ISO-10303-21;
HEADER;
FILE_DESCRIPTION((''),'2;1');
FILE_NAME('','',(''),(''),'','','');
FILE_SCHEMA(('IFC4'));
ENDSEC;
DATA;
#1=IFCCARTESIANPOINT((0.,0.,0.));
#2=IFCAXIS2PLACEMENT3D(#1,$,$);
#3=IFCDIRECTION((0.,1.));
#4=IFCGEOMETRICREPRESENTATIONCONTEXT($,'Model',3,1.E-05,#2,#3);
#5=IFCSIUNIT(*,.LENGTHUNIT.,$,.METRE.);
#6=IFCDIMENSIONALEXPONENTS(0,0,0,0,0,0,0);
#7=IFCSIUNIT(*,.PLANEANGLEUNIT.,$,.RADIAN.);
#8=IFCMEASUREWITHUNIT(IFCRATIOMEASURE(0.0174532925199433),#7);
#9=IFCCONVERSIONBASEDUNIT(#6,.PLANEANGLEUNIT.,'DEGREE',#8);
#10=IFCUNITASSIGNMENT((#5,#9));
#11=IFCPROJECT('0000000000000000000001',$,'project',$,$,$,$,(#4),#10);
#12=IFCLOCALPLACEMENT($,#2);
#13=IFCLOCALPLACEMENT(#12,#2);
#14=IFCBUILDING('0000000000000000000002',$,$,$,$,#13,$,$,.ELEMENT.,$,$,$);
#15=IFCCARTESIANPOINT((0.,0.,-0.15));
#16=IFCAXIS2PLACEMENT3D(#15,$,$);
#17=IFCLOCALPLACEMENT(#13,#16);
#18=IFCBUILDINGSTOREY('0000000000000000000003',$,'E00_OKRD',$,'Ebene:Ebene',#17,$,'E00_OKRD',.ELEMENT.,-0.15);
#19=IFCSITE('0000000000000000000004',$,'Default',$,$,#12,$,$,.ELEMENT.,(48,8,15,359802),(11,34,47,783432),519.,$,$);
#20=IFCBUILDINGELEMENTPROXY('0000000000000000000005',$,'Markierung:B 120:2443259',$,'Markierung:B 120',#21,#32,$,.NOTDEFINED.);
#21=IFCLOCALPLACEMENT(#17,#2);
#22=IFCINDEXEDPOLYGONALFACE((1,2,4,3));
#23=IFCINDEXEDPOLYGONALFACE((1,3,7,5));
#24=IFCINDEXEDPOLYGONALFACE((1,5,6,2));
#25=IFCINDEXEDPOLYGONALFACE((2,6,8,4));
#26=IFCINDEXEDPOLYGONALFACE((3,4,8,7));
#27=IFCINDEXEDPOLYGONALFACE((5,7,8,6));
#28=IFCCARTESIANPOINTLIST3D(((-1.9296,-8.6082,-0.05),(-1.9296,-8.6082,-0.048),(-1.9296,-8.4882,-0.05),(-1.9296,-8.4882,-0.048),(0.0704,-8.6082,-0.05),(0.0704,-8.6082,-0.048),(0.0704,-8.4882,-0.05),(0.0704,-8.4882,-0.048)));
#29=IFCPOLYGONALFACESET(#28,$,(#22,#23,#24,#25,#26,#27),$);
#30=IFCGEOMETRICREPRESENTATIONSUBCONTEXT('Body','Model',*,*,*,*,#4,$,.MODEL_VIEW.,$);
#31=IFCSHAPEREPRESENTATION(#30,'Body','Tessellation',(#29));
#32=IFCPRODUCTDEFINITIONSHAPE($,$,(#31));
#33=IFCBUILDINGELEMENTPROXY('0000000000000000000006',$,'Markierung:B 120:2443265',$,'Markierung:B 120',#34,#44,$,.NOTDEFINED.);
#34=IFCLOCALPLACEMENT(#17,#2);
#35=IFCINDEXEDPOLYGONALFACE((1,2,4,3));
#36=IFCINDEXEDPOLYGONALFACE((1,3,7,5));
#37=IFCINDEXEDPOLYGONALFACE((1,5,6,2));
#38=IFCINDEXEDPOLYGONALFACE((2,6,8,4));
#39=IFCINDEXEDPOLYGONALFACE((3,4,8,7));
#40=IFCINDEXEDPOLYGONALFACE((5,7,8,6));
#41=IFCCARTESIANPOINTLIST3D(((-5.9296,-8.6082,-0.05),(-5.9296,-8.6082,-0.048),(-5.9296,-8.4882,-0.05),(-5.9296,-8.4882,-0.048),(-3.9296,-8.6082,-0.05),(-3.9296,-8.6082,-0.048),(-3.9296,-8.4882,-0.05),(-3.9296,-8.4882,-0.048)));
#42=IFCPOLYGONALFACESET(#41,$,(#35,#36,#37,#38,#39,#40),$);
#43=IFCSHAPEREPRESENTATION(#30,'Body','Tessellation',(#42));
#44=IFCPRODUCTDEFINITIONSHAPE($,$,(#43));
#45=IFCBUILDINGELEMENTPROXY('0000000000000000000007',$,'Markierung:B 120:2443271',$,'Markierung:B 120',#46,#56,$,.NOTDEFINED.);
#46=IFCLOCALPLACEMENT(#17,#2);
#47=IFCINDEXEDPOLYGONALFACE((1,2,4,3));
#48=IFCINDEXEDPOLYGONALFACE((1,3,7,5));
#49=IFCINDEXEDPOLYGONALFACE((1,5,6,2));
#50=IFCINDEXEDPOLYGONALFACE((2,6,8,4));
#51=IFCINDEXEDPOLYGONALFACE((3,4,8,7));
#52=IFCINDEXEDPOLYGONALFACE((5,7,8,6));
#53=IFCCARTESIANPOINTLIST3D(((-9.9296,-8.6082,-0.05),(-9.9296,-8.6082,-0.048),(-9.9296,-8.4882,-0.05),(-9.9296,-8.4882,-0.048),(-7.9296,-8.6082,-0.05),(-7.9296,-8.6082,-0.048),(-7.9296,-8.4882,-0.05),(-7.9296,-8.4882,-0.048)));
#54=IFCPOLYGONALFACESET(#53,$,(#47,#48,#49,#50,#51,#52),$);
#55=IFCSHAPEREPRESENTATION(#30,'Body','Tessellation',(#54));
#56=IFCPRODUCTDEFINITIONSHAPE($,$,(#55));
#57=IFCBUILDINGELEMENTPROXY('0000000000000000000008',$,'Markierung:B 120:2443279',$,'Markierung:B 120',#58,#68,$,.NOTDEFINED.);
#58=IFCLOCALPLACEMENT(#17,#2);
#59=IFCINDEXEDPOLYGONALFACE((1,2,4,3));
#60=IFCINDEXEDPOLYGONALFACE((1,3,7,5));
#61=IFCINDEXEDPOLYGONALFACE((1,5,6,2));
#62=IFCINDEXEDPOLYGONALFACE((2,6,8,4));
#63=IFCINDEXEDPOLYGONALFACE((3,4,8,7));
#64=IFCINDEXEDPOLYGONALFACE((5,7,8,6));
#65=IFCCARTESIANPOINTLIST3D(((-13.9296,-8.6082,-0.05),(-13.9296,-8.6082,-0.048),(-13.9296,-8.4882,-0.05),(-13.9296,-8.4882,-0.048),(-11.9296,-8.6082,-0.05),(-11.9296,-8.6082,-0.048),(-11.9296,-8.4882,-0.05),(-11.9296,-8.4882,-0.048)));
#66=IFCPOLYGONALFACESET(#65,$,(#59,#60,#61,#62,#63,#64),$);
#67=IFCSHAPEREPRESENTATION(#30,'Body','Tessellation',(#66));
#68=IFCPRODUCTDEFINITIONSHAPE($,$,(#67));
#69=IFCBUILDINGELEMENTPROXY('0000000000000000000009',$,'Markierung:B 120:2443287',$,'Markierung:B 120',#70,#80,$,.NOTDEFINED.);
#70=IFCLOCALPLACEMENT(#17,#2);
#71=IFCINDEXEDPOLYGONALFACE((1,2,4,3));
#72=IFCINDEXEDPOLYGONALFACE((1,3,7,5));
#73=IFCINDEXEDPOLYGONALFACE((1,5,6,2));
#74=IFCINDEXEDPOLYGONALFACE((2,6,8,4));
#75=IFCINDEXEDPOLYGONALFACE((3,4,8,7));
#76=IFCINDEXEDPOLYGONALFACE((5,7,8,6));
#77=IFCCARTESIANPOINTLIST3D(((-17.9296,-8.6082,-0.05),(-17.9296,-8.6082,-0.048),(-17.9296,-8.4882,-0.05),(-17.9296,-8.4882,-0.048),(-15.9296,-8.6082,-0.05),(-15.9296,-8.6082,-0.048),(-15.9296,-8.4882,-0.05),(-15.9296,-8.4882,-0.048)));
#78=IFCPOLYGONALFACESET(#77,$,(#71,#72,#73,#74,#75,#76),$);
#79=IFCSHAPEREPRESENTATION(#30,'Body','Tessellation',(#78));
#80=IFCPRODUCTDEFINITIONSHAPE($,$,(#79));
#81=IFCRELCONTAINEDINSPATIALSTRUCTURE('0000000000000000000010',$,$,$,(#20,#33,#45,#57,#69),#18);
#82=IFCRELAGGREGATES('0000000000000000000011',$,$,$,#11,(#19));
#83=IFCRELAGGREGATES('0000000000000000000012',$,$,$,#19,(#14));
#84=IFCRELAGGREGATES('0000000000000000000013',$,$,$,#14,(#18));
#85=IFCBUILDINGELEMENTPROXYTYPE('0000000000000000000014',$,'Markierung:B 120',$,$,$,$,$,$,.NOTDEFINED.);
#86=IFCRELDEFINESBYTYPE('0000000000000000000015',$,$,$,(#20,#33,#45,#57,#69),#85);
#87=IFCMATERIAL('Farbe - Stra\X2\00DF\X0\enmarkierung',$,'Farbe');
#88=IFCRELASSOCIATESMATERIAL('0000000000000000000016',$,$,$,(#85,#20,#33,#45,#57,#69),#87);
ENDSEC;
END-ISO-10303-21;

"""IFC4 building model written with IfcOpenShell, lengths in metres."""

from ifc_helpers import new_model, entity, si_unit, converted_unit, direction, frame, frame_2d, origin, place, context, subcontext, project, spatial, rectangle, extrude, source, transform, mapped, material, type_object, type_shapes, element, save


model = new_model("IFC4")

# Units and contexts
model_context = context("Model", 3, precision=1e-05, world=origin(), true_north=direction((0.0, 1.0)))
body_context = subcontext(model_context, "Body", "Model", "MODEL_VIEW")
ifc_project = project(units=[si_unit("LENGTHUNIT", "METRE"), converted_unit("PLANEANGLEUNIT", "DEGREE", entity("IfcRatioMeasure", 0.0174532925199433), si_unit("PLANEANGLEUNIT", "RADIAN"), dimensions=[0, 0, 0, 0, 0, 0, 0])], contexts=[model_context])

# Site, building, storey
site_placement = place(None, frame((0.0, 0.0, 0.0)))
site = spatial("IfcSite", under=ifc_project, at=site_placement, Name="Default", CompositionType="ELEMENT", RefLatitude=(48, 8, 15, 359802), RefLongitude=(11, 34, 47, 783432), RefElevation=519.0)
building_placement = place(site_placement, origin())
building = spatial("IfcBuilding", under=site, at=building_placement, CompositionType="ELEMENT")
storey_placement = place(building_placement, frame((0.0, 0.0, -0.15)))
storey = spatial("IfcBuildingStorey", under=building, at=storey_placement, Name="E00_OKRD", ObjectType="Ebene:Ebene", LongName="E00_OKRD", CompositionType="ELEMENT", Elevation=-0.15)

# Building element proxies
ifc_material_1 = material(Name="Farbe - Straßenmarkierung", Category="Farbe")
building_element_proxy_type = type_object("IfcBuildingElementProxyType", Name="Markierung:B 120", PredefinedType="NOTDEFINED", material=ifc_material_1)
shared_shape_1 = source(origin(), body_context, "Body", "SweptSolid", [
    extrude(rectangle(XDim=0.12, YDim=2.0, at=frame_2d((0.0, 0.0), x_axis=(1.0, 0.0))), frame((0.06, 1.0, 0.0), z_axis=(0.0, 0.0, 1.0), x_axis=(-1.0, 0.0, 0.0)), (0.0, 0.0, 1.0), 0.002),
])
type_shapes(building_element_proxy_type, [shared_shape_1])
for number, where, z_axis, x_axis, name in (
    (1, (0.0704, -8.6082, -0.05), (0.0, 0.0, 1.0), (0.0, 1.0, 0.0), "Markierung:B 120:2443259"),
    (2, (-3.9296, -8.6082, -0.05), (0.0, 0.0, 1.0), (0.0, 1.0, 0.0), "Markierung:B 120:2443265"),
    (3, (-7.9296, -8.6082, -0.05), (0.0, 0.0, 1.0), (0.0, 1.0, 0.0), "Markierung:B 120:2443271"),
    (4, (-11.9296, -8.6082, -0.05), (0.0, 0.0, 1.0), (0.0, 1.0, 0.0), "Markierung:B 120:2443279"),
    (5, (-15.9296, -8.6082, -0.05), (0.0, 0.0, 1.0), (0.0, 1.0, 0.0), "Markierung:B 120:2443287"),
):
    element("IfcBuildingElementProxy", number, at=place(storey_placement, frame(where, z_axis=z_axis, x_axis=x_axis)), inside=storey, type_object=building_element_proxy_type, material=ifc_material_1, Name=name, ObjectType="Markierung:B 120", PredefinedType="NOTDEFINED", context=body_context, shape_type="MappedRepresentation", body=[
        mapped(shared_shape_1, transform((0.0, 0.0, 0.0), scale=1.0)),
    ])

save(model, "model.ifc")
